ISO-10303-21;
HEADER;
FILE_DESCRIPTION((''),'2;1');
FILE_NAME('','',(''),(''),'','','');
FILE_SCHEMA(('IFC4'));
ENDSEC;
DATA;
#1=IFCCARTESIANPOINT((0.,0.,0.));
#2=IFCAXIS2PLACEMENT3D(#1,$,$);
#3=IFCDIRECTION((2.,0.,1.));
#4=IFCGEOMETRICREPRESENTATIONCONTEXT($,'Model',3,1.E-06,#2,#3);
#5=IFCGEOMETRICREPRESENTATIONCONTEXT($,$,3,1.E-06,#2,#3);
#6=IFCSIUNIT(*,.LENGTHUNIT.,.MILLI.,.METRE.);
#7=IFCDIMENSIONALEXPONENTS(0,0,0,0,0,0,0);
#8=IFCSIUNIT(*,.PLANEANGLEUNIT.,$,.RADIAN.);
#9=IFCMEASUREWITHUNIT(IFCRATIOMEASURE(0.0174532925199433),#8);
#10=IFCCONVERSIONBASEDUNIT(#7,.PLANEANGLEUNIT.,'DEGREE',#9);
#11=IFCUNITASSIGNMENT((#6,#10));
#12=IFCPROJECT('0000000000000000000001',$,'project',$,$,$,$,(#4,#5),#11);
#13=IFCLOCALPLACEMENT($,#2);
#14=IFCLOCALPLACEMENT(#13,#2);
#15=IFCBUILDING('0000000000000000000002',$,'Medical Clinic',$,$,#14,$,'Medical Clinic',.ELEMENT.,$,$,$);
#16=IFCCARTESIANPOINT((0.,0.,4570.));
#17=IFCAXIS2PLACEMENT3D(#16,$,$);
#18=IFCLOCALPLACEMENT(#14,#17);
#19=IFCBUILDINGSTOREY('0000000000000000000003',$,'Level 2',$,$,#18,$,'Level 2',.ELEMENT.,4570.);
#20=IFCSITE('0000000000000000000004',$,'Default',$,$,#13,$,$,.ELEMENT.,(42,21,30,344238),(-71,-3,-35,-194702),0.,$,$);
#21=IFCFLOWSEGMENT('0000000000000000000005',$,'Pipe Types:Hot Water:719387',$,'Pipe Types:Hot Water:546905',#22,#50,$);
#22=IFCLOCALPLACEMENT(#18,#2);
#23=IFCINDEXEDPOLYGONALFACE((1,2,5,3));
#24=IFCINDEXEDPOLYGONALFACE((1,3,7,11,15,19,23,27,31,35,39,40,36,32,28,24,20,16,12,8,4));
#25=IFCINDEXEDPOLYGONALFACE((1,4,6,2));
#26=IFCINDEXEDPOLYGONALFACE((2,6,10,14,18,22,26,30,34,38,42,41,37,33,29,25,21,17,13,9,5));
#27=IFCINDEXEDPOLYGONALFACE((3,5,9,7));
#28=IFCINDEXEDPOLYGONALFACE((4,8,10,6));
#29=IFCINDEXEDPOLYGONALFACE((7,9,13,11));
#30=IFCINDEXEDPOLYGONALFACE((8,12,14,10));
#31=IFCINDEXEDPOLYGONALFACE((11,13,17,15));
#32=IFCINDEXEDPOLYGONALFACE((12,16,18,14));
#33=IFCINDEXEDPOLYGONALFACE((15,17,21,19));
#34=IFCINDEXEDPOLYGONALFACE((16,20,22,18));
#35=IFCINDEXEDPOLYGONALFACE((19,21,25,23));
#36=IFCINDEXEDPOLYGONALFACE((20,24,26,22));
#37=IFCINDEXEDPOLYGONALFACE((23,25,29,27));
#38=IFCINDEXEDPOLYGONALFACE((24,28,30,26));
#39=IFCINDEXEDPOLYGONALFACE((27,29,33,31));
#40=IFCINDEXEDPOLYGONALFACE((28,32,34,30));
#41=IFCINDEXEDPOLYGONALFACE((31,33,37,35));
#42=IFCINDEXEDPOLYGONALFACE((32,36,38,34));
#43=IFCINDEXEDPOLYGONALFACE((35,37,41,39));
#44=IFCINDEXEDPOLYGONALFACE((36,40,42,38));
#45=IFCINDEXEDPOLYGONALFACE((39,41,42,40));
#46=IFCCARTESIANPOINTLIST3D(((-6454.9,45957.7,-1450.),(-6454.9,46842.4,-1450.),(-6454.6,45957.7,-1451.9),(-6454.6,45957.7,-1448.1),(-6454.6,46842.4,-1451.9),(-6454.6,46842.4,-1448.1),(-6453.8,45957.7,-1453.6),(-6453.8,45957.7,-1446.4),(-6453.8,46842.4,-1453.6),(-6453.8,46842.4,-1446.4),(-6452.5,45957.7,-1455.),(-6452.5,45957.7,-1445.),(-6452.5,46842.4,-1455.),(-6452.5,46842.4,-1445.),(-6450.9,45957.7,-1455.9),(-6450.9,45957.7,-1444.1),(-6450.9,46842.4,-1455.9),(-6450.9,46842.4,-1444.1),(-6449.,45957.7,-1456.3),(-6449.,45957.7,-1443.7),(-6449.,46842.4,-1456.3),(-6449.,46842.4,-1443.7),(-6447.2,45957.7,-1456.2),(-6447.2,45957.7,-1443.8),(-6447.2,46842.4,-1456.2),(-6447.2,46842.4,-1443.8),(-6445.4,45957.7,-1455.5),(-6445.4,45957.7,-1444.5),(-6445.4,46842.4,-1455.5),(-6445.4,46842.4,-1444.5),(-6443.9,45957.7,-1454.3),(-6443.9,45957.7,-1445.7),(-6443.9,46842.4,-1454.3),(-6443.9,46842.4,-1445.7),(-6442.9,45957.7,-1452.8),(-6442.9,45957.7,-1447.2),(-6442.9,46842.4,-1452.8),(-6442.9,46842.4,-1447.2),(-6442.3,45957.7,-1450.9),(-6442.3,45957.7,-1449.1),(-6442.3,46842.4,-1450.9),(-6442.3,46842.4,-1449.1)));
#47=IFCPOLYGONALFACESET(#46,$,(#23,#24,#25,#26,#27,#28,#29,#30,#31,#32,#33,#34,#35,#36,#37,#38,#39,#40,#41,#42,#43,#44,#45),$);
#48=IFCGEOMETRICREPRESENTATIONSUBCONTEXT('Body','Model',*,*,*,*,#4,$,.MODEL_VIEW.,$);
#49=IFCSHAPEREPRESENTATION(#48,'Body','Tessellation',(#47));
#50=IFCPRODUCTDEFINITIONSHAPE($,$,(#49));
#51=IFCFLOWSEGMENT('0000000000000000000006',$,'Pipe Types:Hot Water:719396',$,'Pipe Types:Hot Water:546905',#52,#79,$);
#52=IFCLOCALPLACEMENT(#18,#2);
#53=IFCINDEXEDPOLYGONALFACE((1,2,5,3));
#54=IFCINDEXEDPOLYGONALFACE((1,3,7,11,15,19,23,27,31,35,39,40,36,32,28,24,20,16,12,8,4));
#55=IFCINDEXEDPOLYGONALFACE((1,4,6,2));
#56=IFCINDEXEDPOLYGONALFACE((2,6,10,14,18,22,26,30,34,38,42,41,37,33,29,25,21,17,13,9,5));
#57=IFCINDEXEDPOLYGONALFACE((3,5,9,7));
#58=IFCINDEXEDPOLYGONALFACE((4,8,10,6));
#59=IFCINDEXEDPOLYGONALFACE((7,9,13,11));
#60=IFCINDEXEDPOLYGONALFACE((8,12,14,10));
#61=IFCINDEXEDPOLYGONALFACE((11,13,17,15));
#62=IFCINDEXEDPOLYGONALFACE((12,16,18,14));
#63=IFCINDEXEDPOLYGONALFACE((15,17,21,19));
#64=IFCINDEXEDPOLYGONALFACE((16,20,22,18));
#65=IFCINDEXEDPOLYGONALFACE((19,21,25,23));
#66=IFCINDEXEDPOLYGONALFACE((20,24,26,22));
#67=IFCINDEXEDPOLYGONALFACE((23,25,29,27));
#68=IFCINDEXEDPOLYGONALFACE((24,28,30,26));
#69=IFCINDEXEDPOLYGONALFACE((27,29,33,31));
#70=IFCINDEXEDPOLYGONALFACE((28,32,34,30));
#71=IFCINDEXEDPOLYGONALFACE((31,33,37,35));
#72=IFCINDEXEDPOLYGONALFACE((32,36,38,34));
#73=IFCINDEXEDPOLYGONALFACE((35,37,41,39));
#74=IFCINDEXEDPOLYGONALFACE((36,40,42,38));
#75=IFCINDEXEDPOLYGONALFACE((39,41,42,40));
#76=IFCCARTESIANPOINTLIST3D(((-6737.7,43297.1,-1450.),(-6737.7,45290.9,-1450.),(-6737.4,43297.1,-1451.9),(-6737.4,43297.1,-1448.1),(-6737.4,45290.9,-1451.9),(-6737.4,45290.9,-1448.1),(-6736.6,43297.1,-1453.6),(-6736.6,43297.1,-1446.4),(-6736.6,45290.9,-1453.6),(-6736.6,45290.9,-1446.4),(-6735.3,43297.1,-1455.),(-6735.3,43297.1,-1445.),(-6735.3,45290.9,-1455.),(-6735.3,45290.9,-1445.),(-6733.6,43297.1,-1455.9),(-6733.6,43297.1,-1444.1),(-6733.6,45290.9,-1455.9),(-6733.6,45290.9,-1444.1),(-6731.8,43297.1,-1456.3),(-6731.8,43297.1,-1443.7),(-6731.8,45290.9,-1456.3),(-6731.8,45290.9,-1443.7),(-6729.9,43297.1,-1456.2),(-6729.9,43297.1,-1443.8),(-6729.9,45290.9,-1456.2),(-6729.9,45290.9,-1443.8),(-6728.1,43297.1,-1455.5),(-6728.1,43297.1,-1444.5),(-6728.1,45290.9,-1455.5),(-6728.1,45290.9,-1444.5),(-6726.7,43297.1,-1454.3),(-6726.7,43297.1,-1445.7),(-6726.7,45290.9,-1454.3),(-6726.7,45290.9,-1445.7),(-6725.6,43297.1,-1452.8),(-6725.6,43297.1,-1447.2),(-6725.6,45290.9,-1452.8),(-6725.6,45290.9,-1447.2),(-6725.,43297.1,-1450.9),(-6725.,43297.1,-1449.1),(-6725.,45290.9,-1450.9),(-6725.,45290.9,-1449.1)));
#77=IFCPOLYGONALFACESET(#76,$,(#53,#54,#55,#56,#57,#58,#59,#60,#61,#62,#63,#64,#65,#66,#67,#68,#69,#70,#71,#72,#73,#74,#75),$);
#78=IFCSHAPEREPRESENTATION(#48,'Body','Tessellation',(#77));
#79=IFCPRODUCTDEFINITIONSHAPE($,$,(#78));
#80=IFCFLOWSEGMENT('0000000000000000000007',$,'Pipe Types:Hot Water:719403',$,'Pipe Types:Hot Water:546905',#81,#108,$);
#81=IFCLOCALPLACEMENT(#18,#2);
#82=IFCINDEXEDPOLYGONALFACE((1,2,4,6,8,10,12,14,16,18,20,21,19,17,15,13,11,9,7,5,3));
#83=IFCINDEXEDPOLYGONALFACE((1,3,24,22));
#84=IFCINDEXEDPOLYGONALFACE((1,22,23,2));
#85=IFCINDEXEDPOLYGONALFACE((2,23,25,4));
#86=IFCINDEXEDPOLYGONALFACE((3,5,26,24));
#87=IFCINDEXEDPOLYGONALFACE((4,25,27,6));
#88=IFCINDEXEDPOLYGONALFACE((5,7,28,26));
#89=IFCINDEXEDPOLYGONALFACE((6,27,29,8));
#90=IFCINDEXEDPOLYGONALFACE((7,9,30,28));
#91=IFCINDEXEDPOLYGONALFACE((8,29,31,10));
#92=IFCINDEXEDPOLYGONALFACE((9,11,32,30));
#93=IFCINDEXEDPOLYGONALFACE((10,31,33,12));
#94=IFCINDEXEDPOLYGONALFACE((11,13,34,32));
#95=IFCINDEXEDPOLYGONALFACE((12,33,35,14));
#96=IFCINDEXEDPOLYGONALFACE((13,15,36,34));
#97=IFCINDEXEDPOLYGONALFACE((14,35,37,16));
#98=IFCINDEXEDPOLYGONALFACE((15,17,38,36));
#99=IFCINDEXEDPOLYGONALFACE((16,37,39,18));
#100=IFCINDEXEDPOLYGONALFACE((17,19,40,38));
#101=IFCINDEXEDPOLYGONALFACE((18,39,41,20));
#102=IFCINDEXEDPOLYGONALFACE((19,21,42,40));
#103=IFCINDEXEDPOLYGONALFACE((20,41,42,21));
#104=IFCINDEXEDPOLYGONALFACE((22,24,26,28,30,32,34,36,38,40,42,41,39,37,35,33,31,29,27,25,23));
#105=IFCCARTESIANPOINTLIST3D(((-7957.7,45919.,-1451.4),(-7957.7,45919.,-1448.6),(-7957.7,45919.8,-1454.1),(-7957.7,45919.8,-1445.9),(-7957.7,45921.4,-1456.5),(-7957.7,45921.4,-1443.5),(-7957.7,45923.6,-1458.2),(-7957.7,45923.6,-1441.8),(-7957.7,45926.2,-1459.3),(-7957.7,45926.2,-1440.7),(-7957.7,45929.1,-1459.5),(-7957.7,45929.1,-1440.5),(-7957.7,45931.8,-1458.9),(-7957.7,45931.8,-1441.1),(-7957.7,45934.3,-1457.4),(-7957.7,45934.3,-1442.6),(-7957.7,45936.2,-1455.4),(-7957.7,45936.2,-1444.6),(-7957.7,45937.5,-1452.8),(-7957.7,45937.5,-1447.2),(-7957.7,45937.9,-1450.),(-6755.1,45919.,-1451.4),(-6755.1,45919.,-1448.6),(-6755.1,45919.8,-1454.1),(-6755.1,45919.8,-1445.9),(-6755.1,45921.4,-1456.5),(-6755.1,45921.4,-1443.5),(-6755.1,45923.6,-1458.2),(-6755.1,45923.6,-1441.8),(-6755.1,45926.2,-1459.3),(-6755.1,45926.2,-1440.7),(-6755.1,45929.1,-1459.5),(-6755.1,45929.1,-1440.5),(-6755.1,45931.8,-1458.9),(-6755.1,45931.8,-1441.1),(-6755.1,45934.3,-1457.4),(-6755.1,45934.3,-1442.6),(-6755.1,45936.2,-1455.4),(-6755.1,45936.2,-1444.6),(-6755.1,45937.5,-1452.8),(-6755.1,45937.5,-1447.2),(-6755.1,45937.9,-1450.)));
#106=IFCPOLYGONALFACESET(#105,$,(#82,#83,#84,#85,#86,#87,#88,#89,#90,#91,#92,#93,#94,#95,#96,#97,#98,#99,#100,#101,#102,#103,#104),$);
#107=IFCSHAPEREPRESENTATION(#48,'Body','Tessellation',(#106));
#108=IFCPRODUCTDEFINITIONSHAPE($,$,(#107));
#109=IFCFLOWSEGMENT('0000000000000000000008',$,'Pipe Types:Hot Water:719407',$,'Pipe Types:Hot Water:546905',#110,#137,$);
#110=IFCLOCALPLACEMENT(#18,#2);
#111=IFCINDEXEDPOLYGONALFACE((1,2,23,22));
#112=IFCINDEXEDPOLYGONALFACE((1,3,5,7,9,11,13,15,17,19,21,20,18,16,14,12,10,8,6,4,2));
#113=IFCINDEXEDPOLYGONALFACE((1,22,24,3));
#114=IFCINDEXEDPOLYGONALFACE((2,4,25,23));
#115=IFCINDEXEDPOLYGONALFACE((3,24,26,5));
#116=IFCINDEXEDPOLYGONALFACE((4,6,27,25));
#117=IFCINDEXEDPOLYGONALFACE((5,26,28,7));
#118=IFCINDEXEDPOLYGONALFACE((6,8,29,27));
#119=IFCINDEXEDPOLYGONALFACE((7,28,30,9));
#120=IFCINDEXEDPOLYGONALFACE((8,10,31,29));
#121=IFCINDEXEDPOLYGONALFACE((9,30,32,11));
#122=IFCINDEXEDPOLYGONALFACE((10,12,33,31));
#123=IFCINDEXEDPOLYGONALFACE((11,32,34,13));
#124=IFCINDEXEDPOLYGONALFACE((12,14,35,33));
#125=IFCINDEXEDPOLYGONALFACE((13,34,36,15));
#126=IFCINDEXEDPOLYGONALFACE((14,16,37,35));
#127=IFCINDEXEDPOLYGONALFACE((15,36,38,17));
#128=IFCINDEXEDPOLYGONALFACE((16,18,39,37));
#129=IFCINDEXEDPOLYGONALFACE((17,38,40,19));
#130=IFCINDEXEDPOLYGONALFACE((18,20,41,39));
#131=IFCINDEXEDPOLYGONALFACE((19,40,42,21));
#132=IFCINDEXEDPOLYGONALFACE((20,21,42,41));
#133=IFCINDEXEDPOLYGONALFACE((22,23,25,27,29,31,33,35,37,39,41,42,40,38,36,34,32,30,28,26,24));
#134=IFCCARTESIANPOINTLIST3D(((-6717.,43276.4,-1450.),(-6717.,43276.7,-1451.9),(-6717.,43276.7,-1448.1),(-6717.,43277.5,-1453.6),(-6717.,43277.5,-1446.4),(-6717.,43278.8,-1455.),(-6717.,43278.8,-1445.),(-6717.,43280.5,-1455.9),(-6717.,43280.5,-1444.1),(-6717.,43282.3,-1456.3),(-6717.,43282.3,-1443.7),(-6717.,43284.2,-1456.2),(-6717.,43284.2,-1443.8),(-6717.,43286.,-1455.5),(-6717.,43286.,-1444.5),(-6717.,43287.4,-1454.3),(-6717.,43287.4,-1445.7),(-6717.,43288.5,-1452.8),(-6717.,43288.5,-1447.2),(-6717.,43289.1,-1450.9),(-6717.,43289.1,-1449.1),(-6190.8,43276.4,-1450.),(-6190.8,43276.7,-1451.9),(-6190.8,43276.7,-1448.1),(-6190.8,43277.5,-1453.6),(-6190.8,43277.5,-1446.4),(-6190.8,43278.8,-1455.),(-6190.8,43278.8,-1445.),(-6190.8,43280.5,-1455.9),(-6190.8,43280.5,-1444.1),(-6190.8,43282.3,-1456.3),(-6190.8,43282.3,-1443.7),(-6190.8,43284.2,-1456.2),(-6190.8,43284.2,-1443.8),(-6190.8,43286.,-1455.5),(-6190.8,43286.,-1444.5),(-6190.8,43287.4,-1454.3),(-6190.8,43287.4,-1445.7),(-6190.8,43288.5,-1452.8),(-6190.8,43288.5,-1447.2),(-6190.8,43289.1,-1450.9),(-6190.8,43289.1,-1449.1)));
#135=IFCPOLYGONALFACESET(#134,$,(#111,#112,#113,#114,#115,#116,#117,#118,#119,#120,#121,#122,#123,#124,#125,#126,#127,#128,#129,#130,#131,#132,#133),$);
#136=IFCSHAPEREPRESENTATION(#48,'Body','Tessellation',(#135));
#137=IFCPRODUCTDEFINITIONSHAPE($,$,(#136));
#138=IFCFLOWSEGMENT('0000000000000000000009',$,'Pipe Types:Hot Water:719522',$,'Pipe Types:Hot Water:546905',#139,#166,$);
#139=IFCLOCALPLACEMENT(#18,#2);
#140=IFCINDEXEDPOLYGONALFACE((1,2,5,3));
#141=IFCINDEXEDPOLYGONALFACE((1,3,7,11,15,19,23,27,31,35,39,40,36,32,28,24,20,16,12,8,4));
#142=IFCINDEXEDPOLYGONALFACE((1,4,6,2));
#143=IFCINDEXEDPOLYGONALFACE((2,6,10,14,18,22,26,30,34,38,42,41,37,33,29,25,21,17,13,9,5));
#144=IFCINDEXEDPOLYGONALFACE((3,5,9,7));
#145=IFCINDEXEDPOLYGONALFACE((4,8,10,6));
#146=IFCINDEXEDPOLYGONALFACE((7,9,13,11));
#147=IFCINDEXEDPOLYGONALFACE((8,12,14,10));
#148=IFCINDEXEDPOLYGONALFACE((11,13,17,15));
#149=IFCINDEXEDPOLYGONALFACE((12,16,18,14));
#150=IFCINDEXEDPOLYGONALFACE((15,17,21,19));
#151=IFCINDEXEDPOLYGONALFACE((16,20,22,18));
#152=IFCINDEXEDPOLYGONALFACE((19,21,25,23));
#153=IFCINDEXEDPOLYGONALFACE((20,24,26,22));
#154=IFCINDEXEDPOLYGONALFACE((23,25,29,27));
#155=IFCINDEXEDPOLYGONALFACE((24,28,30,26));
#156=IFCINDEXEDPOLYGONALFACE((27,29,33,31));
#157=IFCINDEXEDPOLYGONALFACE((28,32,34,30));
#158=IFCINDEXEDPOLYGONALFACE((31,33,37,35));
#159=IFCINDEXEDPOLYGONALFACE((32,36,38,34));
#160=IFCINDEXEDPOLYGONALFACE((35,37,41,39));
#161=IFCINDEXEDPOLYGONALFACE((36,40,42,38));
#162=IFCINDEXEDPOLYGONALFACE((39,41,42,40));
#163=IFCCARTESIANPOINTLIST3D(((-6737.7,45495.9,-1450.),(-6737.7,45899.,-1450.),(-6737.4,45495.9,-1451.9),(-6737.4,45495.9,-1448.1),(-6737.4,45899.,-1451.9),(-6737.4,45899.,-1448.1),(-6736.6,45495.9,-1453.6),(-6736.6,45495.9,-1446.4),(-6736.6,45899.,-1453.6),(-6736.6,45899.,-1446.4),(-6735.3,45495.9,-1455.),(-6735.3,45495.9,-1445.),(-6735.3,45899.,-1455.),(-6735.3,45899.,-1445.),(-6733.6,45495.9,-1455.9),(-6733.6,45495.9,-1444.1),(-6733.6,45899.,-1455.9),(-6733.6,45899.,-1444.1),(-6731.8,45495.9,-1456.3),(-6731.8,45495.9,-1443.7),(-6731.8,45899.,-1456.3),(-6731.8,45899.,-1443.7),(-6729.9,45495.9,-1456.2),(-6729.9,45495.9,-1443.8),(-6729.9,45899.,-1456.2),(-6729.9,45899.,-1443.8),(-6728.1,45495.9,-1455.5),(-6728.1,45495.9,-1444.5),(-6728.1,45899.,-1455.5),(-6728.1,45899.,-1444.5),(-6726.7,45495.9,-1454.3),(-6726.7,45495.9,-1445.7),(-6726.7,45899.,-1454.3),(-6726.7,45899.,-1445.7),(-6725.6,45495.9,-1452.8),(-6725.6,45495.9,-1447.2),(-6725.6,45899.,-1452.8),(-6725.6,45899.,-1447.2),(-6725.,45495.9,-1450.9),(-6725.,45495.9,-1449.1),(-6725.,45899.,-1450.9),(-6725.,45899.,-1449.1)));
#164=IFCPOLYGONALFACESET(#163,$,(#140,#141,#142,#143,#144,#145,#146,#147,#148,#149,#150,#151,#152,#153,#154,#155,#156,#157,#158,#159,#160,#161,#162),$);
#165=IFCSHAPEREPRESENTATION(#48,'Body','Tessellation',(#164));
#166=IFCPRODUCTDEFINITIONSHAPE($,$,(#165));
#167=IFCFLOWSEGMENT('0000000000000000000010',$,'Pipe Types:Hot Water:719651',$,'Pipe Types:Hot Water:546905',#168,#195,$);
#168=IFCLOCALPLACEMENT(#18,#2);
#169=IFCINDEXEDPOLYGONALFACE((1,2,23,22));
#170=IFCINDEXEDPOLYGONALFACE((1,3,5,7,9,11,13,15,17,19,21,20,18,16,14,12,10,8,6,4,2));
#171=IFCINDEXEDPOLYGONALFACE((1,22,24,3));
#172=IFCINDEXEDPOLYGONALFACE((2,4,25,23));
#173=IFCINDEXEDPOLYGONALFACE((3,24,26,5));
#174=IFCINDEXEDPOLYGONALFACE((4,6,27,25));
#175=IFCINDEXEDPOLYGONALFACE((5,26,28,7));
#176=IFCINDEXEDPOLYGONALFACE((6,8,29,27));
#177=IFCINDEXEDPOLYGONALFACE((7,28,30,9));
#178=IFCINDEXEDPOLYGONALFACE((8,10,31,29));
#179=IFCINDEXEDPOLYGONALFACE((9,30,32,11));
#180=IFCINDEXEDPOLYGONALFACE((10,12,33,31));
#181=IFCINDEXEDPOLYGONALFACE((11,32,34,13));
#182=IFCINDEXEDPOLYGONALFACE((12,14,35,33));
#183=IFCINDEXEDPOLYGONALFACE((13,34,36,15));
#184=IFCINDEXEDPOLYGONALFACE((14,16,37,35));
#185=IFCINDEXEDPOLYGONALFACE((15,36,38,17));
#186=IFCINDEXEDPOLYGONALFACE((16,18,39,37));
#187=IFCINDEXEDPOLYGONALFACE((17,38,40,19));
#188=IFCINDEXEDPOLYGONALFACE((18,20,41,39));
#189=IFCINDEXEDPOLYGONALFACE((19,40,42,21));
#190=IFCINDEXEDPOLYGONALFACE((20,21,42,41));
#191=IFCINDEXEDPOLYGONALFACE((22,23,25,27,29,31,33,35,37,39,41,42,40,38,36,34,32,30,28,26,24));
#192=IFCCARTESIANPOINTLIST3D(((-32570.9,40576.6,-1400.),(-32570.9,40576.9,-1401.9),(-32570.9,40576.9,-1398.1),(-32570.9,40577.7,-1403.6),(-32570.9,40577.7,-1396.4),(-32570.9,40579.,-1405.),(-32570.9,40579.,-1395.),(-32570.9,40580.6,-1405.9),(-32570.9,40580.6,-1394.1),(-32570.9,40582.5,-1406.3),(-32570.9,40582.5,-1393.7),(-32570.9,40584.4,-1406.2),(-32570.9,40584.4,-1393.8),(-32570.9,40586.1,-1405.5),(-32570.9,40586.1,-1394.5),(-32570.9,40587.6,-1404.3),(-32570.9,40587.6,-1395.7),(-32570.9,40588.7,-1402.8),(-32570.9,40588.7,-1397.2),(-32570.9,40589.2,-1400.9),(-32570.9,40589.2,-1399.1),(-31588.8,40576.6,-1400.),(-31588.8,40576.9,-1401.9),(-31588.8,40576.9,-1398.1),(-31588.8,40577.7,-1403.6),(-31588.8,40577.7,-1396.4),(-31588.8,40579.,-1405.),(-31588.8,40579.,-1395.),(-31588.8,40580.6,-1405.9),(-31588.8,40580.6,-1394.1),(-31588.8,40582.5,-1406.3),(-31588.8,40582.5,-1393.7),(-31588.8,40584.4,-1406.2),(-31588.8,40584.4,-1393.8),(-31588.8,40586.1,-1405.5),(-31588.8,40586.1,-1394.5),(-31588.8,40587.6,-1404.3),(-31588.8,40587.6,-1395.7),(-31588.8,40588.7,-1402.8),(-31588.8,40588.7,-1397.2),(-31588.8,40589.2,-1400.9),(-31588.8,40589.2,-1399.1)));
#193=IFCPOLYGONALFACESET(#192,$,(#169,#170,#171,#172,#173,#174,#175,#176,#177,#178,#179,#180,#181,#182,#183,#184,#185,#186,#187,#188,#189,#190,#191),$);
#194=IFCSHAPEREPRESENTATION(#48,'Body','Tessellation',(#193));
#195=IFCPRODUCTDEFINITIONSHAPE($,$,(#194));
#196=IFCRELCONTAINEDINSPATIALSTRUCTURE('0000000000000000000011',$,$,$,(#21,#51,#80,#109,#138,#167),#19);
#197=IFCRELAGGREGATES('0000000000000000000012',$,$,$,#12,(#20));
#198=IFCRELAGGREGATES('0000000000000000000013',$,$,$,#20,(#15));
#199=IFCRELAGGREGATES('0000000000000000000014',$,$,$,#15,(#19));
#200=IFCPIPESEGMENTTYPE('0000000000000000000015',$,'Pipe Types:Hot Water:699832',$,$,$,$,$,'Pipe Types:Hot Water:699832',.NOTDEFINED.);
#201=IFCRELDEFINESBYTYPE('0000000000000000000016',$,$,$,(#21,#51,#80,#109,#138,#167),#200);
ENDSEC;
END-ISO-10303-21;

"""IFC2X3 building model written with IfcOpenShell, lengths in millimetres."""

from ifc_helpers import new_model, entity, si_unit, converted_unit, direction, frame, origin, origin_2d_with_axis, place, context, subcontext, project, spatial, circle, extrude, type_object, element, save


model = new_model("IFC2X3")

# Units and contexts
model_context = context("Model", 3, precision=1e-06, world=origin(), true_north=direction((2.0, 0.0, 1.0)))
context_of_model = context(None, 3, precision=1e-06, world=origin(), true_north=direction((2.0, 0.0, 1.0)))
body_context = subcontext(model_context, "Body", "Model", "MODEL_VIEW")
ifc_project = project(units=[si_unit("LENGTHUNIT", "METRE", prefix="MILLI"), converted_unit("PLANEANGLEUNIT", "DEGREE", entity("IfcRatioMeasure", 0.0174532925199433), si_unit("PLANEANGLEUNIT", "RADIAN"), dimensions=[0, 0, 0, 0, 0, 0, 0])], contexts=[model_context, context_of_model])

# Site, building, storey
site_placement = place(None, origin())
site = spatial("IfcSite", under=ifc_project, at=site_placement, Name="Default", CompositionType="ELEMENT", RefLatitude=(42, 21, 30, 344238), RefLongitude=(-71, -3, -35, -194702), RefElevation=0.0)
building_placement = place(site_placement, origin())
building = spatial("IfcBuilding", under=site, at=building_placement, Name="Medical Clinic", LongName="Medical Clinic", CompositionType="ELEMENT")
storey_placement = place(building_placement, frame((0.0, 0.0, 4570.0)))
storey = spatial("IfcBuildingStorey", under=building, at=storey_placement, Name="Level 2", LongName="Level 2", CompositionType="ELEMENT", Elevation=4570.0)

# Flow segments
pipe_segment_type_1 = type_object("IfcPipeSegmentType", Name="Pipe Types:Hot Water:699832", ElementType="Pipe Types:Hot Water:699832", PredefinedType="NOTDEFINED")
flow_segment_1_placement = place(storey_placement, origin())
element("IfcFlowSegment", 1, at=flow_segment_1_placement, inside=storey, type_object=pipe_segment_type_1, Name="Pipe Types:Hot Water:719387", ObjectType="Pipe Types:Hot Water:546905", context=body_context, shape_type="SweptSolid", body=[
    extrude(circle(Radius=6.3, at=origin_2d_with_axis()), frame((-6448.6, 45957.7, -1450.0), z_axis=(0.0, 1.0, 0.0), x_axis=(-1.0, 0.0, 0.0)), (0.0, 0.0, 1.0), 884.7),
])
flow_segment_2_placement = place(storey_placement, origin())
element("IfcFlowSegment", 2, at=flow_segment_2_placement, inside=storey, type_object=pipe_segment_type_1, Name="Pipe Types:Hot Water:719396", ObjectType="Pipe Types:Hot Water:546905", context=body_context, shape_type="SweptSolid", body=[
    extrude(circle(Radius=6.3, at=origin_2d_with_axis()), frame((-6731.3, 43297.1, -1450.0), z_axis=(0.0, 1.0, 0.0), x_axis=(-1.0, 0.0, 0.0)), (0.0, 0.0, 1.0), 1993.8),
])
flow_segment_3_placement = place(storey_placement, origin())
element("IfcFlowSegment", 3, at=flow_segment_3_placement, inside=storey, type_object=pipe_segment_type_1, Name="Pipe Types:Hot Water:719403", ObjectType="Pipe Types:Hot Water:546905", context=body_context, shape_type="SweptSolid", body=[
    extrude(circle(Radius=9.5, at=origin_2d_with_axis()), frame((-7957.7, 45928.4, -1450.0), z_axis=(1.0, 0.0, 0.0), x_axis=(0.0, 1.0, 0.0)), (0.0, 0.0, 1.0), 1202.5),
])
flow_segment_4_placement = place(storey_placement, origin())
element("IfcFlowSegment", 4, at=flow_segment_4_placement, inside=storey, type_object=pipe_segment_type_1, Name="Pipe Types:Hot Water:719407", ObjectType="Pipe Types:Hot Water:546905", context=body_context, shape_type="SweptSolid", body=[
    extrude(circle(Radius=6.3, at=origin_2d_with_axis()), frame((-6717.0, 43282.8, -1450.0), z_axis=(1.0, 0.0, 0.0), x_axis=(0.0, -1.0, 0.0)), (0.0, 0.0, 1.0), 526.2),
])
flow_segment_5_placement = place(storey_placement, origin())
element("IfcFlowSegment", 5, at=flow_segment_5_placement, inside=storey, type_object=pipe_segment_type_1, Name="Pipe Types:Hot Water:719522", ObjectType="Pipe Types:Hot Water:546905", context=body_context, shape_type="SweptSolid", body=[
    extrude(circle(Radius=6.3, at=origin_2d_with_axis()), frame((-6731.3, 45495.9, -1450.0), z_axis=(0.0, 1.0, 0.0), x_axis=(-1.0, 0.0, 0.0)), (0.0, 0.0, 1.0), 403.1),
])
flow_segment_6_placement = place(storey_placement, origin())
element("IfcFlowSegment", 6, at=flow_segment_6_placement, inside=storey, type_object=pipe_segment_type_1, Name="Pipe Types:Hot Water:719651", ObjectType="Pipe Types:Hot Water:546905", context=body_context, shape_type="SweptSolid", body=[
    extrude(circle(Radius=6.3, at=origin_2d_with_axis()), frame((-32570.9, 40582.9, -1400.0), z_axis=(1.0, 0.0, 0.0), x_axis=(0.0, -1.0, 0.0)), (0.0, 0.0, 1.0), 982.1),
])

save(model, "model.ifc")
